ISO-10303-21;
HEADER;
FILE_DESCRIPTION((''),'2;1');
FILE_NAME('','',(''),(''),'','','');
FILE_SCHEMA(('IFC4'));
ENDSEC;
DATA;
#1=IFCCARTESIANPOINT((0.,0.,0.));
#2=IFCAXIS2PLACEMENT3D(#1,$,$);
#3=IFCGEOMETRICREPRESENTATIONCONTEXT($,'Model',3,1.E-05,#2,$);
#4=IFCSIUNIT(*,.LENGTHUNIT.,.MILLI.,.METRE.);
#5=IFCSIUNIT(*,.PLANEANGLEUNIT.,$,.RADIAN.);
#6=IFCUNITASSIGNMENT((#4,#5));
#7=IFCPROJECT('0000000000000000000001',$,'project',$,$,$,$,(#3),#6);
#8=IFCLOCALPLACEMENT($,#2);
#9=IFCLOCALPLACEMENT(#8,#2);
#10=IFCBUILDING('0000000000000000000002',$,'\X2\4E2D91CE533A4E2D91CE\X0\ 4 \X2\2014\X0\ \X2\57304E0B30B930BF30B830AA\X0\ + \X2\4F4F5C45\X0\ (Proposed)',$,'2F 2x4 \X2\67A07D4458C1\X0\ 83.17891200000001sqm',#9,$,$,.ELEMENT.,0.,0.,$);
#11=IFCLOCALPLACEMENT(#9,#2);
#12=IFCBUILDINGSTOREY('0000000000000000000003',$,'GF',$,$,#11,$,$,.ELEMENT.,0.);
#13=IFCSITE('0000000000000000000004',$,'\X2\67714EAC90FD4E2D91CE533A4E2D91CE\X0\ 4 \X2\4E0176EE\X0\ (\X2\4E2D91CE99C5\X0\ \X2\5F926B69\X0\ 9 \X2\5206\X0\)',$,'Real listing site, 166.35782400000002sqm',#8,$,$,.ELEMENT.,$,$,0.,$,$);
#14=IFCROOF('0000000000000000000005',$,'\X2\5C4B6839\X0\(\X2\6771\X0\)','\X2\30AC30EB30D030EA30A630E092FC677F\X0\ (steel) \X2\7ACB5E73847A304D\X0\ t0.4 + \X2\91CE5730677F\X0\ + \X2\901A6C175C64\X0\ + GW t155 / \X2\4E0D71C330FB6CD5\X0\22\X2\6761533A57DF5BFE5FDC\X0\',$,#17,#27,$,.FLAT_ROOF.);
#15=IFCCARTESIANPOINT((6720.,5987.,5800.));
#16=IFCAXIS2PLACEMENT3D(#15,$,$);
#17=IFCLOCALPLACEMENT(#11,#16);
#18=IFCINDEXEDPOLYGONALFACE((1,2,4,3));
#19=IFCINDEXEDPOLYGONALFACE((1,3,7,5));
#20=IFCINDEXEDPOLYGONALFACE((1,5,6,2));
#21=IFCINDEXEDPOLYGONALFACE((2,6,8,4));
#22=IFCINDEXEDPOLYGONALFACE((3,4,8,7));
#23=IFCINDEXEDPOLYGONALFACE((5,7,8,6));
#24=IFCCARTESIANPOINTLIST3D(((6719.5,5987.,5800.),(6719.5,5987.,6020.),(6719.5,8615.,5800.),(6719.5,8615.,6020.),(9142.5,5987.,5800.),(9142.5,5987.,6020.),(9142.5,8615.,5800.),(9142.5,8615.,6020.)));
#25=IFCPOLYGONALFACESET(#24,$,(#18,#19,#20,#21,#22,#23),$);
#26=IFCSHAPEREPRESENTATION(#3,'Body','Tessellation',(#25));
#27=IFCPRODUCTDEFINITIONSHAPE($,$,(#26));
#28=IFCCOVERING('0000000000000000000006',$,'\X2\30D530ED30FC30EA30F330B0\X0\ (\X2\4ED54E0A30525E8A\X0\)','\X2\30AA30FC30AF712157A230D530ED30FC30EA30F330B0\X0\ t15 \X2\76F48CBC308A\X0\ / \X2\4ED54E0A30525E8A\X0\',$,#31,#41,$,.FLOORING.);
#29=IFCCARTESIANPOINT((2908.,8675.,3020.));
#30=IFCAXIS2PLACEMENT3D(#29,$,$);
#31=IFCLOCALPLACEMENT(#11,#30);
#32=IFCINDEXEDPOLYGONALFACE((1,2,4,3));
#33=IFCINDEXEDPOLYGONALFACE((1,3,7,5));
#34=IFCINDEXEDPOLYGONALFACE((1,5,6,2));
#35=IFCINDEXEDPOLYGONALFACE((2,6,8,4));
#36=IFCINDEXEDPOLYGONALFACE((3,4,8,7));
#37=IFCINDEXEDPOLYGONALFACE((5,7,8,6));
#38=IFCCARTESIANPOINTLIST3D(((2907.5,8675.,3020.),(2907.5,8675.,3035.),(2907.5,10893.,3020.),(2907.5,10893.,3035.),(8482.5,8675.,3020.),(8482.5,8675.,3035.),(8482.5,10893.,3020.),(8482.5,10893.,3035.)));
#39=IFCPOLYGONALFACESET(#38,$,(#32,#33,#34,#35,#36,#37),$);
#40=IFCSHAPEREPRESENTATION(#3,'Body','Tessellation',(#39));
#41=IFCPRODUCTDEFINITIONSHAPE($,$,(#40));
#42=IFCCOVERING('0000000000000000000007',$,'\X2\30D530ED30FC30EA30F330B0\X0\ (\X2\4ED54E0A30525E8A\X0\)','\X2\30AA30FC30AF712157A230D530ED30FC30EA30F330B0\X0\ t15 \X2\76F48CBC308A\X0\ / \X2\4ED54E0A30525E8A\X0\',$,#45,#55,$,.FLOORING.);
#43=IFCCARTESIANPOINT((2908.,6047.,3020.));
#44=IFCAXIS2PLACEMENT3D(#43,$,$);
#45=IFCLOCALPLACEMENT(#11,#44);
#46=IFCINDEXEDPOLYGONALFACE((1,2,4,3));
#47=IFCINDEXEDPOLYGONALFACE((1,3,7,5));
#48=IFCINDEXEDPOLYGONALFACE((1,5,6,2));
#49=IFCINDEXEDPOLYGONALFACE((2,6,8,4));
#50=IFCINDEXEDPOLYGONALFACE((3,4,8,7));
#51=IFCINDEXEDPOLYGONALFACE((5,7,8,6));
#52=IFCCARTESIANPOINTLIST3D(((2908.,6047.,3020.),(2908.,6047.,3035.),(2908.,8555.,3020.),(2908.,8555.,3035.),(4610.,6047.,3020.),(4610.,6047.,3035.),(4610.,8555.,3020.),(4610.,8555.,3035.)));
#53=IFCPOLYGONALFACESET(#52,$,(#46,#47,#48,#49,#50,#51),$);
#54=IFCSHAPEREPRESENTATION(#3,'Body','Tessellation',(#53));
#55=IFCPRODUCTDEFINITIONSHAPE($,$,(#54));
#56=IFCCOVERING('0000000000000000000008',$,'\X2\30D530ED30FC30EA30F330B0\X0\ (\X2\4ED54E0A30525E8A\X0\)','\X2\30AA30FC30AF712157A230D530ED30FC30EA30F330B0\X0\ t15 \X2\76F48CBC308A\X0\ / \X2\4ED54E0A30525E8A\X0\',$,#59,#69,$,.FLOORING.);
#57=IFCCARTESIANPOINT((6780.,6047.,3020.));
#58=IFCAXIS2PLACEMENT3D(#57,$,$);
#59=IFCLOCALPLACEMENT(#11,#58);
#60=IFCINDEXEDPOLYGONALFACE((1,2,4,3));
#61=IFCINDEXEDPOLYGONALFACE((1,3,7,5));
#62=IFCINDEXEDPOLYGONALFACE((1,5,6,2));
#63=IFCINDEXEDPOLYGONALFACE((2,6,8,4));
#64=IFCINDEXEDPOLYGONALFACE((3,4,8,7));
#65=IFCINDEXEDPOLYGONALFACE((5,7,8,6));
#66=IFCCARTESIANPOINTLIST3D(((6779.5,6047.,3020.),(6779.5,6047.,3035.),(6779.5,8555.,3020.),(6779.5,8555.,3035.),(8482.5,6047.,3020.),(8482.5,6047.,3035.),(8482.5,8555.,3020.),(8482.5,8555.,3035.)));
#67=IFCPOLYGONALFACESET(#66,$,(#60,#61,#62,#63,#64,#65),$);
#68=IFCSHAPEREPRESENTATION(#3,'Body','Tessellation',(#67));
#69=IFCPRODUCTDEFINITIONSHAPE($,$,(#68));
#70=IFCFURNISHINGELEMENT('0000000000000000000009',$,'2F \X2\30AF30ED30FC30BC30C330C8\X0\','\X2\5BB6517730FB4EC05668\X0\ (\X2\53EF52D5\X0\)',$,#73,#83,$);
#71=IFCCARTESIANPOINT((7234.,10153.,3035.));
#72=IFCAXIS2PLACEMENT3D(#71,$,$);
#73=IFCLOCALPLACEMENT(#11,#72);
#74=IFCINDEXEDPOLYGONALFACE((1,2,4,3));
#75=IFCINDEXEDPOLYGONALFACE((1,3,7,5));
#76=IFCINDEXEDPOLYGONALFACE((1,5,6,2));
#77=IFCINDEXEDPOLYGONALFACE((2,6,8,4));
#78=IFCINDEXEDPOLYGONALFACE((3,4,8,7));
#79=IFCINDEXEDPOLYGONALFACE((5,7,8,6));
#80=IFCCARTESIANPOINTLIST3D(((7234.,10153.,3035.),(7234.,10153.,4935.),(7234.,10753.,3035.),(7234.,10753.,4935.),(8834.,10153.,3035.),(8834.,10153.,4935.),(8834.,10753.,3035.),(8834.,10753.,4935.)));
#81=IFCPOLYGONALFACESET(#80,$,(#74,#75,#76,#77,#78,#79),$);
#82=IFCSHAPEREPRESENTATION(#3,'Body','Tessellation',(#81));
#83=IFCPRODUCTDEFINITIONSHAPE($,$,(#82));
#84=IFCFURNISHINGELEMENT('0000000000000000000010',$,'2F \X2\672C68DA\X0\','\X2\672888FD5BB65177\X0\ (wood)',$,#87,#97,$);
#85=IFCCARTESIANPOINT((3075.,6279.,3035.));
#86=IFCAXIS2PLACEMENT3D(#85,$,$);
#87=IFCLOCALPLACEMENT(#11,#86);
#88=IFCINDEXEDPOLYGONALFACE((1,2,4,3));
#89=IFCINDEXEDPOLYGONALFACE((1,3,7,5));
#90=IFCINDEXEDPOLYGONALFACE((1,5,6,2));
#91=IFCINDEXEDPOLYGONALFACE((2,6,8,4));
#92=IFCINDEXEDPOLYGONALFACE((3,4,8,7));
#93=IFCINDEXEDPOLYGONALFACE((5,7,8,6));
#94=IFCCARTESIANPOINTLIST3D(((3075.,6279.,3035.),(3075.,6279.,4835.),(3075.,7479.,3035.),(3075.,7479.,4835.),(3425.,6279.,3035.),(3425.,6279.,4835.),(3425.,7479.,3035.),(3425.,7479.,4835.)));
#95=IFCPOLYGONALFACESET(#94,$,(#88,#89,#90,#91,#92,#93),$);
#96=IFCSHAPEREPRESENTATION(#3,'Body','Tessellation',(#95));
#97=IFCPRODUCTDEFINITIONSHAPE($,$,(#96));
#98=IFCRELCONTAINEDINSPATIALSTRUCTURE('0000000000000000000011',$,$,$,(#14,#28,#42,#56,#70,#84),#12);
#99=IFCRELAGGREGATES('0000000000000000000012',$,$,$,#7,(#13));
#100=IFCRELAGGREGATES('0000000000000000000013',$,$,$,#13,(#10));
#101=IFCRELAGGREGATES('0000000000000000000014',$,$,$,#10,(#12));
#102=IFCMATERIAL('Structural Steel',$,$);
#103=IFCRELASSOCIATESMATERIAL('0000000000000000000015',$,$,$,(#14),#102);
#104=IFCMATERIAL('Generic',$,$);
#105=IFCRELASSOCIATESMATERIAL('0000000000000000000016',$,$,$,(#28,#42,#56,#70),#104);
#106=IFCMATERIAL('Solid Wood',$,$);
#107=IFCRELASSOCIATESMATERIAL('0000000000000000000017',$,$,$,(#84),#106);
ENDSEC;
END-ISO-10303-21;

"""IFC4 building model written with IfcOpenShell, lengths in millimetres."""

from ifc_helpers import new_model, si_unit, frame, frame_2d, origin, place, context, project, spatial, rectangle, extrude, material, element, save


model = new_model("IFC4")

# Units and contexts
model_context = context("Model", 3, precision=1e-05, world=origin())
ifc_project = project(units=[si_unit("LENGTHUNIT", "METRE", prefix="MILLI"), si_unit("PLANEANGLEUNIT", "RADIAN")], contexts=[model_context])

# Site, building, storey
site_placement = place(None, origin())
site = spatial("IfcSite", under=ifc_project, at=site_placement, Name="東京都中野区中野 4 丁目 (中野駅 徒歩 9 分)", ObjectType="Real listing site, 166.35782400000002sqm", CompositionType="ELEMENT", RefElevation=0.0)
building_placement = place(site_placement, origin())
building = spatial("IfcBuilding", under=site, at=building_placement, Name="中野区中野 4 — 地下スタジオ + 住居 (Proposed)", ObjectType="2F 2x4 枠組壁 83.17891200000001sqm", CompositionType="ELEMENT", ElevationOfRefHeight=0.0, ElevationOfTerrain=0.0)
storey_placement = place(building_placement, origin())
storey = spatial("IfcBuildingStorey", under=building, at=storey_placement, Name="GF", CompositionType="ELEMENT", Elevation=0.0)

# Shared definitions
ifc_material_1 = material(Name="Solid Wood")

# Roof
ifc_material_2 = material(Name="Structural Steel")
roof_1_placement = place(storey_placement, frame((6720.0, 5987.0, 5800.0)))
element("IfcRoof", 1, at=roof_1_placement, inside=storey, material=ifc_material_2, Name="屋根(東)", Description="ガルバリウム鋼板 (steel) 立平葺き t0.4 + 野地板 + 通気層 + GW t155 / 不燃・法22条区域対応", PredefinedType="FLAT_ROOF", context=model_context, shape_type="SweptSolid", body=[
    extrude(rectangle(XDim=2423.0, YDim=2628.0, at=frame_2d((1211.0, 1314.0))), frame((6720.0, 5987.0, 5800.0)), (0.0, 0.0, 1.0), 220.0),
])

# Coverings
ifc_material_3 = material(Name="Generic")
covering_1_placement = place(storey_placement, frame((2908.0, 8675.0, 3020.0)))
element("IfcCovering", 2, at=covering_1_placement, inside=storey, material=ifc_material_3, Name="フローリング (仕上げ床)", Description="オーク無垢フローリング t15 直貼り / 仕上げ床", PredefinedType="FLOORING", context=model_context, shape_type="SweptSolid", body=[
    extrude(rectangle(XDim=5575.0, YDim=2218.0, at=frame_2d((2787.0, 1109.0))), frame((2908.0, 8675.0, 3020.0)), (0.0, 0.0, 1.0), 15.0),
])
covering_2_placement = place(storey_placement, frame((2908.0, 6047.0, 3020.0)))
element("IfcCovering", 3, at=covering_2_placement, inside=storey, material=ifc_material_3, Name="フローリング (仕上げ床)", Description="オーク無垢フローリング t15 直貼り / 仕上げ床", PredefinedType="FLOORING", context=model_context, shape_type="SweptSolid", body=[
    extrude(rectangle(XDim=1702.0, YDim=2508.0, at=frame_2d((851.0, 1254.0))), frame((2908.0, 6047.0, 3020.0)), (0.0, 0.0, 1.0), 15.0),
])
covering_3_placement = place(storey_placement, frame((6780.0, 6047.0, 3020.0)))
element("IfcCovering", 4, at=covering_3_placement, inside=storey, material=ifc_material_3, Name="フローリング (仕上げ床)", Description="オーク無垢フローリング t15 直貼り / 仕上げ床", PredefinedType="FLOORING", context=model_context, shape_type="SweptSolid", body=[
    extrude(rectangle(XDim=1703.0, YDim=2508.0, at=frame_2d((851.0, 1254.0))), frame((6780.0, 6047.0, 3020.0)), (0.0, 0.0, 1.0), 15.0),
])

# Furnishing elements
furnishing_1_placement = place(storey_placement, frame((7234.0, 10153.0, 3035.0)))
element("IfcFurnishingElement", 5, at=furnishing_1_placement, inside=storey, material=ifc_material_3, Name="2F クローゼット", Description="家具・什器 (可動)", context=model_context, shape_type="SweptSolid", body=[
    extrude(rectangle(XDim=1600.0, YDim=600.0, at=frame_2d((800.0, 300.0))), frame((7234.0, 10153.0, 3035.0)), (0.0, 0.0, 1.0), 1900.0),
])
furnishing_2_placement = place(storey_placement, frame((3075.0, 6279.0, 3035.0)))
element("IfcFurnishingElement", 6, at=furnishing_2_placement, inside=storey, material=ifc_material_1, Name="2F 本棚", Description="木製家具 (wood)", context=model_context, shape_type="SweptSolid", body=[
    extrude(rectangle(XDim=350.0, YDim=1200.0, at=frame_2d((175.0, 600.0))), frame((3075.0, 6279.0, 3035.0)), (0.0, 0.0, 1.0), 1800.0),
])

save(model, "model.ifc")
